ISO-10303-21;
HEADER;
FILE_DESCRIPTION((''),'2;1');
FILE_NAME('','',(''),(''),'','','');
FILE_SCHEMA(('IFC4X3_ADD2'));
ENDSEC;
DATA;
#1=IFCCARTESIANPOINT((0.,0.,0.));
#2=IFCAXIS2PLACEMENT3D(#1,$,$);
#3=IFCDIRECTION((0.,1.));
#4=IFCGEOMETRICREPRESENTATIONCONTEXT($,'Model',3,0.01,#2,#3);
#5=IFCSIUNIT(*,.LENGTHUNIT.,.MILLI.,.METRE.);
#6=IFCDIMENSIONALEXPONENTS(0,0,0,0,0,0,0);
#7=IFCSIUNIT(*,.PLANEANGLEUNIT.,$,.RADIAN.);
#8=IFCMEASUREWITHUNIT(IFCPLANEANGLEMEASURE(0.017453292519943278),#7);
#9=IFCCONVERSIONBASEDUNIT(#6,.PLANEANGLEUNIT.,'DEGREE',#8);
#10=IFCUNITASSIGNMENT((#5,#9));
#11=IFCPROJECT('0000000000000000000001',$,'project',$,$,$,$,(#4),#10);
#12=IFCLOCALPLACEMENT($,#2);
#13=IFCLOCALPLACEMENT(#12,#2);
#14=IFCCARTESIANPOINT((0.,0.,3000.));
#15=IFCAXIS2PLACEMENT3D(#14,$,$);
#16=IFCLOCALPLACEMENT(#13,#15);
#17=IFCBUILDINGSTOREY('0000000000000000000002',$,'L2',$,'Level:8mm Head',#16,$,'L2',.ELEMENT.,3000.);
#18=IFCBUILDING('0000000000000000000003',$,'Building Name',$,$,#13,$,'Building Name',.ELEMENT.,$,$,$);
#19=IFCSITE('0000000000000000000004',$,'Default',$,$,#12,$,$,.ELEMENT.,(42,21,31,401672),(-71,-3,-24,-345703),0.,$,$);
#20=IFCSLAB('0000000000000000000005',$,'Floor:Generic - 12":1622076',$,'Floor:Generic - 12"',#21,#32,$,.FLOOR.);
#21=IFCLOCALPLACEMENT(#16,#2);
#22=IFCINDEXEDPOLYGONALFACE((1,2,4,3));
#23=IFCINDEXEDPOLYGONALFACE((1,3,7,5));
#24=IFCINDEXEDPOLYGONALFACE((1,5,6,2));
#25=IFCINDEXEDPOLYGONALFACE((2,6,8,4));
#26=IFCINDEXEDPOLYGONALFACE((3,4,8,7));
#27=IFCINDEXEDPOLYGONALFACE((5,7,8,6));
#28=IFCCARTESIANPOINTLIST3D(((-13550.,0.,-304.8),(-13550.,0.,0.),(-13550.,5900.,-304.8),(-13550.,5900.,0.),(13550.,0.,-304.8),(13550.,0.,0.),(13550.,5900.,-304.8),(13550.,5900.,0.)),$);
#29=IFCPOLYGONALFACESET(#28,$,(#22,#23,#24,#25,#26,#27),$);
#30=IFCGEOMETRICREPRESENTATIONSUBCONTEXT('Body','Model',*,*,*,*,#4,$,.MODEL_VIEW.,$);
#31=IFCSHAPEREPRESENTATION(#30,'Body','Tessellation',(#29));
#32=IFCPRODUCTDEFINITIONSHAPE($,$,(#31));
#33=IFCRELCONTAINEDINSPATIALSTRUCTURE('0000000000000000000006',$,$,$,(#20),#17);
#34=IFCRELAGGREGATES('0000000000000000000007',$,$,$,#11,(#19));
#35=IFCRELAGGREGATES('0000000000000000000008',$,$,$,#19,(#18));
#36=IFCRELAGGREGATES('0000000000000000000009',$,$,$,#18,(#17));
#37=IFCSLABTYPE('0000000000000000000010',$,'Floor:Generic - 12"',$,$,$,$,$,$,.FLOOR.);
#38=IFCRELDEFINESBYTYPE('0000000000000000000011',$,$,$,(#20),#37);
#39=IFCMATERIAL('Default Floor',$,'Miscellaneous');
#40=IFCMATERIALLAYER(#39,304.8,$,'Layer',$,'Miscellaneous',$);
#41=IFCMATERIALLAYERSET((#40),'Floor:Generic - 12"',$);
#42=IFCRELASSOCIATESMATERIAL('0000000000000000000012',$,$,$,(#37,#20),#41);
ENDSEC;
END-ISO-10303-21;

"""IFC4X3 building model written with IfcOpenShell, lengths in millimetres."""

from ifc_helpers import new_model, entity, si_unit, converted_unit, direction, frame, origin, origin_2d_with_axis, place, context, subcontext, project, spatial, rectangle, extrude, material, layer, layer_set, layer_usage, type_object, element, save


model = new_model("IFC4X3")

# Units and contexts
model_context = context("Model", 3, precision=0.01, world=origin(), true_north=direction((0.0, 1.0)))
body_context = subcontext(model_context, "Body", "Model", "MODEL_VIEW")
ifc_project = project(units=[si_unit("LENGTHUNIT", "METRE", prefix="MILLI"), converted_unit("PLANEANGLEUNIT", "DEGREE", entity("IfcPlaneAngleMeasure", 0.017453292519943278), si_unit("PLANEANGLEUNIT", "RADIAN"), dimensions=[0, 0, 0, 0, 0, 0, 0])], contexts=[model_context])

# Site, building, storey
site_placement = place(None, origin())
site = spatial("IfcSite", under=ifc_project, at=site_placement, Name="Default", CompositionType="ELEMENT", RefLatitude=(42, 21, 31, 401672), RefLongitude=(-71, -3, -24, -345703), RefElevation=0.0)
building_placement = place(site_placement, origin())
building = spatial("IfcBuilding", under=site, at=building_placement, Name="Building Name", LongName="Building Name", CompositionType="ELEMENT")
storey_placement = place(building_placement, frame((0.0, 0.0, 3000.0)))
storey = spatial("IfcBuildingStorey", under=building, at=storey_placement, Name="L2", ObjectType="Level:8mm Head", LongName="L2", CompositionType="ELEMENT", Elevation=3000.0)

# Slab
ifc_material = material(Name="Default Floor", Category="Miscellaneous")
ifc_layer = layer(ifc_material, 304.8, Name="Layer", Category="Miscellaneous")
ifc_layer_set = layer_set([ifc_layer], Name="Floor:Generic - 12\"")
ifc_layer_usage = layer_usage(ifc_layer_set, "AXIS3", "POSITIVE", 0.0)
slab_type = type_object("IfcSlabType", Name="Floor:Generic - 12\"", PredefinedType="FLOOR", material=ifc_layer_set)
slab_placement = place(storey_placement, origin())
element("IfcSlab", 1, at=slab_placement, inside=storey, type_object=slab_type, material=ifc_layer_usage, Name="Floor:Generic - 12\":1622076", ObjectType="Floor:Generic - 12\"", PredefinedType="FLOOR", context=body_context, shape_type="SweptSolid", body=[
    extrude(rectangle(XDim=5900.0, YDim=27100.0, at=origin_2d_with_axis()), frame((0.0, 2950.0, 0.0), z_axis=(0.0, 0.0, -1.0), x_axis=(0.0, 1.0, 0.0)), (0.0, 0.0, 1.0), 304.8),
])

save(model, "model.ifc")
